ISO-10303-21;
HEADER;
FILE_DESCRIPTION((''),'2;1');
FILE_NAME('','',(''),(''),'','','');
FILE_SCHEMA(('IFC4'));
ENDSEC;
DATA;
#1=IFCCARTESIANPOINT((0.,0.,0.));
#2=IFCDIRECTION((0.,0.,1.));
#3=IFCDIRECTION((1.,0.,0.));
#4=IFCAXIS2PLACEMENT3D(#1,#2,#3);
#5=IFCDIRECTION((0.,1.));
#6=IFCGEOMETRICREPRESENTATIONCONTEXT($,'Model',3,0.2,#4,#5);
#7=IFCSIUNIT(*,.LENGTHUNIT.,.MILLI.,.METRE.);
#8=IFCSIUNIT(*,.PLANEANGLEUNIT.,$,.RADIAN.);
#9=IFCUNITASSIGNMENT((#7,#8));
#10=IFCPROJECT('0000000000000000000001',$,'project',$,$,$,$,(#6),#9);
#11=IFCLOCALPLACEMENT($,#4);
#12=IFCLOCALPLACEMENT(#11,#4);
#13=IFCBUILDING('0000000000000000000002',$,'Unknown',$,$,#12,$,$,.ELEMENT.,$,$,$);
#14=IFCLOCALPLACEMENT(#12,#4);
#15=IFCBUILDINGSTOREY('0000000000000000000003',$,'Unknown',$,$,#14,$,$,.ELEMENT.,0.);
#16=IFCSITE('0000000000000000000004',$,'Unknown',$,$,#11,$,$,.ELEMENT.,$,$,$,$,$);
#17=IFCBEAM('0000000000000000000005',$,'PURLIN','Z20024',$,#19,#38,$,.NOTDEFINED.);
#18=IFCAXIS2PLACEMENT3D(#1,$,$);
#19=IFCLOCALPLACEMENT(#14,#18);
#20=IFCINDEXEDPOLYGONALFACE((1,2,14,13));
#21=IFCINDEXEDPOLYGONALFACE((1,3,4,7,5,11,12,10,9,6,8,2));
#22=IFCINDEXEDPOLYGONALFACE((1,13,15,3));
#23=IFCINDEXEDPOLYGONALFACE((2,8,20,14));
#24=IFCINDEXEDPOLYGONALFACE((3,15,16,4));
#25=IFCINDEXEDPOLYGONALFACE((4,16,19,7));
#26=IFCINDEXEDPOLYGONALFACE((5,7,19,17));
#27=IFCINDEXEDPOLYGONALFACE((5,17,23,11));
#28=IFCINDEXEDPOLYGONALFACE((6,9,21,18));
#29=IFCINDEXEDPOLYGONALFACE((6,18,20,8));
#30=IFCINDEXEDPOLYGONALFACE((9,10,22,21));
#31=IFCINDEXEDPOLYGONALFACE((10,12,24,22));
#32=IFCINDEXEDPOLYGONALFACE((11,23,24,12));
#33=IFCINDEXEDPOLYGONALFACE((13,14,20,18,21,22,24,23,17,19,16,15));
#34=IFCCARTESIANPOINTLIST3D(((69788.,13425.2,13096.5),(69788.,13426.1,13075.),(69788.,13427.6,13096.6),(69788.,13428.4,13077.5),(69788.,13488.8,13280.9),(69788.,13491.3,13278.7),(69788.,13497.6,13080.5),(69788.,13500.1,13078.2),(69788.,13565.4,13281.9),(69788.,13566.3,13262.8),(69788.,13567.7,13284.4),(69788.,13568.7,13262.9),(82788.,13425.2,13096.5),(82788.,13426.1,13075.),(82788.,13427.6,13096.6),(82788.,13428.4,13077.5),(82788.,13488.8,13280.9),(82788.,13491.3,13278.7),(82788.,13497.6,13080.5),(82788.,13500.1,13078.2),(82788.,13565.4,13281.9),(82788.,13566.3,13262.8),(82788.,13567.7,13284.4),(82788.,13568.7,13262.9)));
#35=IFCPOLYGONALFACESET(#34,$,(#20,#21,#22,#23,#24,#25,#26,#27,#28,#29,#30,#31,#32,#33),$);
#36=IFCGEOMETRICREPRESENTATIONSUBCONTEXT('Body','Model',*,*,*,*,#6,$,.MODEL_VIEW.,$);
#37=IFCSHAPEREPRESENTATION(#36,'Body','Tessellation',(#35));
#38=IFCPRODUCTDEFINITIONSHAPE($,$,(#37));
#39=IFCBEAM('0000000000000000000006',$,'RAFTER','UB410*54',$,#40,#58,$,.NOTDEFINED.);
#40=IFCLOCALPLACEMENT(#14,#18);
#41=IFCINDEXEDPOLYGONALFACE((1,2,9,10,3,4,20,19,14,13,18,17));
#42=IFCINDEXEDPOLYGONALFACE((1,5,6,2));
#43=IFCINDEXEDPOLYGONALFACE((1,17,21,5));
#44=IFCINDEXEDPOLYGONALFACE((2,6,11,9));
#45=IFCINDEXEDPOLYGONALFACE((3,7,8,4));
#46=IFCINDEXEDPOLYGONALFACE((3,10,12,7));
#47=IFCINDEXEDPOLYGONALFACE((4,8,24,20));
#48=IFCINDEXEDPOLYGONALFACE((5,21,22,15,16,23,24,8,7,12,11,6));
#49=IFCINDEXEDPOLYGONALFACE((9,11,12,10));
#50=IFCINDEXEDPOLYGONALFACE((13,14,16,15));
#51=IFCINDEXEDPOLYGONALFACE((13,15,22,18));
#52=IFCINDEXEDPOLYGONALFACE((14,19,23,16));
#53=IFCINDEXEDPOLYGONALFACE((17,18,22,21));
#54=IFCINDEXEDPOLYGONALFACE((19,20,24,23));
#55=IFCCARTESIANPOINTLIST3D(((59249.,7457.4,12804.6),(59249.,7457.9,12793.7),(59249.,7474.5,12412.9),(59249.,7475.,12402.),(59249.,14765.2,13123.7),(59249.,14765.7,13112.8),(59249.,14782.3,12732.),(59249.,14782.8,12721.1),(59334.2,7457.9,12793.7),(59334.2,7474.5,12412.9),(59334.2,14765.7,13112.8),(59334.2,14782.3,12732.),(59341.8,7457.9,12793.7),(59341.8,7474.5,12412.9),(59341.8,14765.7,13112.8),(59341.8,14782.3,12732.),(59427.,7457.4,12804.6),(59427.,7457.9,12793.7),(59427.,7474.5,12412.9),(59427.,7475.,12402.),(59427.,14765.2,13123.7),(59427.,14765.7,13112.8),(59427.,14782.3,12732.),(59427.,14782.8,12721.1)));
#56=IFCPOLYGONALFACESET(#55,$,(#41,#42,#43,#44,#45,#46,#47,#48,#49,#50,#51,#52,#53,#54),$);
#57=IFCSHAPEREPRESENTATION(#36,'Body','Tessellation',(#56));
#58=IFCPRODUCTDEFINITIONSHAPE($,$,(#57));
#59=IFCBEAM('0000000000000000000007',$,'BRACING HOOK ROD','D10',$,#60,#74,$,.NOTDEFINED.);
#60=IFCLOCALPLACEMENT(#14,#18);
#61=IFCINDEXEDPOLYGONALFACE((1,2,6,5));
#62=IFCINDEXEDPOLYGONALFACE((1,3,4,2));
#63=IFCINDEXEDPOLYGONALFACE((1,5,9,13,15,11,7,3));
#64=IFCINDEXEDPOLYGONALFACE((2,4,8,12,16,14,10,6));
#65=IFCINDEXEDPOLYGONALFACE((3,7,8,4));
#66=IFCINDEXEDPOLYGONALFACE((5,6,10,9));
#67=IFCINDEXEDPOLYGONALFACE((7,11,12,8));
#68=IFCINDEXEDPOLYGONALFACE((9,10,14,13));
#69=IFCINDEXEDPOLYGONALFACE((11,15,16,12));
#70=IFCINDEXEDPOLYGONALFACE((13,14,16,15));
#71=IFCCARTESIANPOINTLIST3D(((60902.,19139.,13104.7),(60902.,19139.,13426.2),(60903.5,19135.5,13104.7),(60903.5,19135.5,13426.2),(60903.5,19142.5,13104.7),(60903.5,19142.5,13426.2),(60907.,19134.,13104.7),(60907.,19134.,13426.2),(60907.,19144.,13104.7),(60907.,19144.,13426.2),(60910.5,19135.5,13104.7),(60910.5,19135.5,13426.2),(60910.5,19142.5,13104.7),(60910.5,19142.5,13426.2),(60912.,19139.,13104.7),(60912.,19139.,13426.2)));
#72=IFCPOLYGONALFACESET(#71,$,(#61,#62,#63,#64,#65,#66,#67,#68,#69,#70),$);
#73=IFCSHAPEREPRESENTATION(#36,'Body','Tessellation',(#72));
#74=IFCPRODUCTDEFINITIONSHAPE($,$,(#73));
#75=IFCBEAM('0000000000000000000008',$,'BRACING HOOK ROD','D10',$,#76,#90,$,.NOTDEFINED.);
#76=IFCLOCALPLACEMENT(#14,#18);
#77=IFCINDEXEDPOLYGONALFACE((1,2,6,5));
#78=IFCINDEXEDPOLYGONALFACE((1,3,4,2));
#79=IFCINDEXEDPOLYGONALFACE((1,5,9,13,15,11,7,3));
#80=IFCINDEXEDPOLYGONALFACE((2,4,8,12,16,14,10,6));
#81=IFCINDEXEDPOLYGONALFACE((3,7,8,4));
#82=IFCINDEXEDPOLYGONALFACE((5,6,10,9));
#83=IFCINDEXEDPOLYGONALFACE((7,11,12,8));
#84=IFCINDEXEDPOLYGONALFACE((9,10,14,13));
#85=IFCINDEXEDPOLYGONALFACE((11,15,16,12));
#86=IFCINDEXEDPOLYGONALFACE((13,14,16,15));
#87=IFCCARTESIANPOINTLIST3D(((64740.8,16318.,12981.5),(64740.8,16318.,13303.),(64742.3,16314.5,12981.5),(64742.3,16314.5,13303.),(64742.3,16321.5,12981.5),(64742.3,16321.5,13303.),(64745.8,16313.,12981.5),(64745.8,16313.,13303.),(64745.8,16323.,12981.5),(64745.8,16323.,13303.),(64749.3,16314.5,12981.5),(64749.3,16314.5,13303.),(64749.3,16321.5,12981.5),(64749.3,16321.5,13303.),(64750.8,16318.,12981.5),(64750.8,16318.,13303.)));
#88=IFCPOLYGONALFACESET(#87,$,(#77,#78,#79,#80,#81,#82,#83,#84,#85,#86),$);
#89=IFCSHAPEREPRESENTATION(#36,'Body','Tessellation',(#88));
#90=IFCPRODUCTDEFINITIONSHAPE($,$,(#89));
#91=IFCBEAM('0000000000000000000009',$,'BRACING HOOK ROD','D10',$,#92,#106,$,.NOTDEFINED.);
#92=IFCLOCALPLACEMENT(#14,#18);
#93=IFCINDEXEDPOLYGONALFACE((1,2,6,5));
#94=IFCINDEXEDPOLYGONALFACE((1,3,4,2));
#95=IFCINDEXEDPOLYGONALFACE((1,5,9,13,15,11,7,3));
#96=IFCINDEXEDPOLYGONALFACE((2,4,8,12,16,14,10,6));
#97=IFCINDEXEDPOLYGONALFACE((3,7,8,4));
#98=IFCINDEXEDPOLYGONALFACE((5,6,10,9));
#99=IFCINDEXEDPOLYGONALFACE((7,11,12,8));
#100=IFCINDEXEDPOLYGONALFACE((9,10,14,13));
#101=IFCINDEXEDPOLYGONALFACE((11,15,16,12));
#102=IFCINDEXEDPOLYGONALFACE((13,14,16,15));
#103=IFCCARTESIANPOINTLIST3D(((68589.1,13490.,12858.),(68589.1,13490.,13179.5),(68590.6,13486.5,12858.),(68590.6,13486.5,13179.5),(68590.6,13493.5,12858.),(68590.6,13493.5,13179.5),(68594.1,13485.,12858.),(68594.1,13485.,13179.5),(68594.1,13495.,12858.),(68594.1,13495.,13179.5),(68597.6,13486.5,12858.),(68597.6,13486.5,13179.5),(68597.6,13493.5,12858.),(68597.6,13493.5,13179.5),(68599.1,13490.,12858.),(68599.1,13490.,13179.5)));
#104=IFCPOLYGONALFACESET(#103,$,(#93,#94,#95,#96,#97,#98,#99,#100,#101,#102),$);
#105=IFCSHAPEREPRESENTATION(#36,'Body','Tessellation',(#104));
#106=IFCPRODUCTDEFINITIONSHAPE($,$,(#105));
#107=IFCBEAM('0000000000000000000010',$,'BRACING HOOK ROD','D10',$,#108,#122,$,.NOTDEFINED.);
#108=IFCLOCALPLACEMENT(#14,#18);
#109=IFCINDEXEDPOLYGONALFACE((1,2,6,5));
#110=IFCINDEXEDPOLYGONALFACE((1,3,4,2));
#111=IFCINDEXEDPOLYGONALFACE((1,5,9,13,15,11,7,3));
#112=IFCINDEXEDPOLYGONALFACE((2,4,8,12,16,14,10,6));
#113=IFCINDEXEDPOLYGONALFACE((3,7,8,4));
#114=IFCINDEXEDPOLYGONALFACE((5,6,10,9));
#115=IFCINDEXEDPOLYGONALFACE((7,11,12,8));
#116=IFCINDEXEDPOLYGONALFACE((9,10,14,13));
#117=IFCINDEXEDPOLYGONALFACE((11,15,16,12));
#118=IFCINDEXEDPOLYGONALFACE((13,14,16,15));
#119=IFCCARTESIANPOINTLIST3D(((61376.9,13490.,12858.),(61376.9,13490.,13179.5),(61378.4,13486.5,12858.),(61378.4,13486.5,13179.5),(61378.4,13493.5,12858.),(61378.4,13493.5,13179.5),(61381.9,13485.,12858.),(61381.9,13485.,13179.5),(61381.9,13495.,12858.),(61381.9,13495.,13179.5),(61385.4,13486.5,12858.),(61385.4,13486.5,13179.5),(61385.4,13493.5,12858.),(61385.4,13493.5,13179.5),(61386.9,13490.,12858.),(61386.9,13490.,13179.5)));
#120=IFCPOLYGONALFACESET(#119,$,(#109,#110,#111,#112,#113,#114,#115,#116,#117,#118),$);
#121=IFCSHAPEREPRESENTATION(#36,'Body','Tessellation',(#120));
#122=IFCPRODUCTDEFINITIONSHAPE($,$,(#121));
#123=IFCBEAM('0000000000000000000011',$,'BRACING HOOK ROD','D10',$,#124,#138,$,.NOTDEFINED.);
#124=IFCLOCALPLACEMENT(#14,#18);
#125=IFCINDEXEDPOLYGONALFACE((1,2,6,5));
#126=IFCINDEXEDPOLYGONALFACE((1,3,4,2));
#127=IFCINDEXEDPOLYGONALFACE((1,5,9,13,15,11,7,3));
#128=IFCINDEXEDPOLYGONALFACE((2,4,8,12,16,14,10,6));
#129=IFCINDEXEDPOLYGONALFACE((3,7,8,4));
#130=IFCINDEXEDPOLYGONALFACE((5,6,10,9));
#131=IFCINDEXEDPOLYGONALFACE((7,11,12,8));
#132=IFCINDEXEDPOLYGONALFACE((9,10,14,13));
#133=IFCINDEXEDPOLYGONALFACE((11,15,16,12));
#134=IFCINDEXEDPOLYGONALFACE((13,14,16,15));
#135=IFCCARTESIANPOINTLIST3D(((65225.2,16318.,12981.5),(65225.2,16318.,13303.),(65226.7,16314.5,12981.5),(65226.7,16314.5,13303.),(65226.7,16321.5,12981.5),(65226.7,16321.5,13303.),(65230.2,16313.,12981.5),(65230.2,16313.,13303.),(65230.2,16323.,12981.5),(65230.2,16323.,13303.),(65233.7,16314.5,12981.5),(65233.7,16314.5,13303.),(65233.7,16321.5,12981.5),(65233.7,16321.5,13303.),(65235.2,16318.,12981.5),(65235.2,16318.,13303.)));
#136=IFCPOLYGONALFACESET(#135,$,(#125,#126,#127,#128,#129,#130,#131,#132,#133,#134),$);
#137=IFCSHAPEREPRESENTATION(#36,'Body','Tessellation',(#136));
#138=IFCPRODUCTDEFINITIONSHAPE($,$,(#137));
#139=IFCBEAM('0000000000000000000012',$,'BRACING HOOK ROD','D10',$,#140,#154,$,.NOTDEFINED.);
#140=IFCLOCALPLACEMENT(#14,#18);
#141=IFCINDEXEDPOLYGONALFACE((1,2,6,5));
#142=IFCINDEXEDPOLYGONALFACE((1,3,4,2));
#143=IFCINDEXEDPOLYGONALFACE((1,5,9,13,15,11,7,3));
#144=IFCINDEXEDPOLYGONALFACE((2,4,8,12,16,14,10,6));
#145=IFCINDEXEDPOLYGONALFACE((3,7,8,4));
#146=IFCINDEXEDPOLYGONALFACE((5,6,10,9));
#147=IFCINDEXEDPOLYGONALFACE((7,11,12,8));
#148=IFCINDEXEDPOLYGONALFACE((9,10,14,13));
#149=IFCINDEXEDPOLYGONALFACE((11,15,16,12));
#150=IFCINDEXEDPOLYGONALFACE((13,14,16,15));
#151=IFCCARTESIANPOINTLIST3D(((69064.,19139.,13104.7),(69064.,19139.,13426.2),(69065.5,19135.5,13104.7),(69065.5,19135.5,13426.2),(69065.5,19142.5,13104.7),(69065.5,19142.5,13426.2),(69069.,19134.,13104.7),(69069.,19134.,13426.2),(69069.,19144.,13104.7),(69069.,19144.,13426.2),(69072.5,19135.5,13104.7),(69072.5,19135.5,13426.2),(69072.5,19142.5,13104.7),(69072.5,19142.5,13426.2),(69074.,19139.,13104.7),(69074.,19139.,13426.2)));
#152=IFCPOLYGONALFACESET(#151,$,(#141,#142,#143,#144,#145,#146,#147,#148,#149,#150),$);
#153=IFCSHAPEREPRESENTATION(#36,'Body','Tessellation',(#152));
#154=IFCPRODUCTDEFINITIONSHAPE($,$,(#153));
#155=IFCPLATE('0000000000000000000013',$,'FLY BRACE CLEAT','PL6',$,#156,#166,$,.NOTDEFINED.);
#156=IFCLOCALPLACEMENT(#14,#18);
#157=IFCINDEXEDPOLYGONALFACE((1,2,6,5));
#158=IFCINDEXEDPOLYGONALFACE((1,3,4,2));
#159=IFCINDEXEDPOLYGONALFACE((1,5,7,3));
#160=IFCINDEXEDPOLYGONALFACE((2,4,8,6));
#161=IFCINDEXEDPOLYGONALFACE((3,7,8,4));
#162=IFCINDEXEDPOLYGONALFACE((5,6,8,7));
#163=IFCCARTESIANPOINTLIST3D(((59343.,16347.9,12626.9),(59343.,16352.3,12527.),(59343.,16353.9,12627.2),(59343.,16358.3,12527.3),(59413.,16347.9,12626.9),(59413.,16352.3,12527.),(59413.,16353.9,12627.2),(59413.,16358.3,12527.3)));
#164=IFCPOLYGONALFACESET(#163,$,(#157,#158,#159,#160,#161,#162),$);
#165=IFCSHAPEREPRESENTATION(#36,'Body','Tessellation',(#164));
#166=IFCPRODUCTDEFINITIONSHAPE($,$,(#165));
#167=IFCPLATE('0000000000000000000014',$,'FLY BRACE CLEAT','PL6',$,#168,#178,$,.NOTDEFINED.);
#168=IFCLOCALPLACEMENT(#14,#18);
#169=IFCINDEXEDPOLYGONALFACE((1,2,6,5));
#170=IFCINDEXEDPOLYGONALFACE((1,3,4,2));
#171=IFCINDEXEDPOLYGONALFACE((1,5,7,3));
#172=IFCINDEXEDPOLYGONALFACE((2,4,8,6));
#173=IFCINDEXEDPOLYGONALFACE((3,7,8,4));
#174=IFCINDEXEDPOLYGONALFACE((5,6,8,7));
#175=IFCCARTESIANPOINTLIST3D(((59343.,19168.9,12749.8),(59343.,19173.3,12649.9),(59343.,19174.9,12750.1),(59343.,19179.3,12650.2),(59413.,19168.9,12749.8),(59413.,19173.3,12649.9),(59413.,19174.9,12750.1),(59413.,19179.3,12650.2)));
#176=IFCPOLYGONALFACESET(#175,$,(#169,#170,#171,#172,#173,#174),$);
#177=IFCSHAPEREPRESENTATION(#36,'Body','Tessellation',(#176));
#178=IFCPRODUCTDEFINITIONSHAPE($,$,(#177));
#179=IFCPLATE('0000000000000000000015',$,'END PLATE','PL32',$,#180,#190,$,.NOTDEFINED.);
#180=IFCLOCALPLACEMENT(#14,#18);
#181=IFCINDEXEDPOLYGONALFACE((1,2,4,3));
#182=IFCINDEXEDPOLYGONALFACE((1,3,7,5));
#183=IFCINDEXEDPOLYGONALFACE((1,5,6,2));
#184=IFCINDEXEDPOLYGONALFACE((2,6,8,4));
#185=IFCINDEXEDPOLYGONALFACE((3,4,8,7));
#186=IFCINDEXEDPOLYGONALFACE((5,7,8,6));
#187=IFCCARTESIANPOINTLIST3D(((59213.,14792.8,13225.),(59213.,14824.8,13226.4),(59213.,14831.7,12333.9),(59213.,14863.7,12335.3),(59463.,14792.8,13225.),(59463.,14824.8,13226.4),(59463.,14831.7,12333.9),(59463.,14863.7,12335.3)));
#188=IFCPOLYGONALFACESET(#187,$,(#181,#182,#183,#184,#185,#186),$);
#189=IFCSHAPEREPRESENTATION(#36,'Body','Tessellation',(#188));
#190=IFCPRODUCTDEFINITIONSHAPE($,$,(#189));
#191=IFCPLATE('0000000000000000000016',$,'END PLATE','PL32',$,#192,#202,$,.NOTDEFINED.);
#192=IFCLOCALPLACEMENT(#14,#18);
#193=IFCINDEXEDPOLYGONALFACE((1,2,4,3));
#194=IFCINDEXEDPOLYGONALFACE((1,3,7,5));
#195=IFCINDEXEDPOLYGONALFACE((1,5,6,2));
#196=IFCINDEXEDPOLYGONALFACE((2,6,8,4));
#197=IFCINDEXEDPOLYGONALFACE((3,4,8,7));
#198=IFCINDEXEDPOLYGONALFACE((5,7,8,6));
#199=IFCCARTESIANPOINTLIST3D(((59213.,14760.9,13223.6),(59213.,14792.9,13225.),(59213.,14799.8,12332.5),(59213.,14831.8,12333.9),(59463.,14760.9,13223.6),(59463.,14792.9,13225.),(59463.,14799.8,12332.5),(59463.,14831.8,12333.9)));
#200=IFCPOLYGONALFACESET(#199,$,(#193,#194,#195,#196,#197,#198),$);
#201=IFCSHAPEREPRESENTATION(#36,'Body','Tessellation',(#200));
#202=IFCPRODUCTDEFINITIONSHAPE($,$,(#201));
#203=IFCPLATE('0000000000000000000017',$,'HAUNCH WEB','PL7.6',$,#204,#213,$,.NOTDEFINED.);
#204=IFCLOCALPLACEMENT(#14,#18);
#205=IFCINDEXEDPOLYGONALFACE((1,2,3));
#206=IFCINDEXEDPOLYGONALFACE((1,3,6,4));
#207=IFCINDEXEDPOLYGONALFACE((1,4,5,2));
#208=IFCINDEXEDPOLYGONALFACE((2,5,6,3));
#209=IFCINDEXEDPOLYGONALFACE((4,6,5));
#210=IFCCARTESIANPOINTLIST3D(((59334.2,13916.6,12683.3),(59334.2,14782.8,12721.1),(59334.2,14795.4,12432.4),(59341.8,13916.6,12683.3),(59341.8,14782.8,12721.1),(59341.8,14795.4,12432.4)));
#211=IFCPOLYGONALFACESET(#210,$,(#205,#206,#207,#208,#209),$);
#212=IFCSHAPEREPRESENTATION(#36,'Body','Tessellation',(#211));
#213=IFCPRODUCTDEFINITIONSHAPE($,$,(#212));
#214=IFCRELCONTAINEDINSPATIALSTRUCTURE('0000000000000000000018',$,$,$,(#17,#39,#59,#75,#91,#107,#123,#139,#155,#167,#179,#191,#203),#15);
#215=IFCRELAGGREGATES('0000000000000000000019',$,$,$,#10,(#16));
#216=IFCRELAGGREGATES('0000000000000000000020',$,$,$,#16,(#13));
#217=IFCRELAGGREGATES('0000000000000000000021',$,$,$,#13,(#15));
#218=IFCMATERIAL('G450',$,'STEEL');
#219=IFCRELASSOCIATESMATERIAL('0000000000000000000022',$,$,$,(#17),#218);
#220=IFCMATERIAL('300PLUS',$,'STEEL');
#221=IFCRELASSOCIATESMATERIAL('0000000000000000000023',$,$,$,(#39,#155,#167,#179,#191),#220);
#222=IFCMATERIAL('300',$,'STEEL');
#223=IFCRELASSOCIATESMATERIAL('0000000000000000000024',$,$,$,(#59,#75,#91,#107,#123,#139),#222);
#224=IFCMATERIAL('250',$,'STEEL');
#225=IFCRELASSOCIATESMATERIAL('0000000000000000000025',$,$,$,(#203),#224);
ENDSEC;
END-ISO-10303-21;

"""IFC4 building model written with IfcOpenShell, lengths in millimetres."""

from ifc_helpers import new_model, si_unit, direction, frame, origin_with_axes, place, context, subcontext, project, spatial, line, indexed_curve, outline, extrude, material, element, save


model = new_model("IFC4")

# Units and contexts
model_context = context("Model", 3, precision=0.2, world=origin_with_axes(), true_north=direction((0.0, 1.0)))
body_context = subcontext(model_context, "Body", "Model", "MODEL_VIEW")
ifc_project = project(units=[si_unit("LENGTHUNIT", "METRE", prefix="MILLI"), si_unit("PLANEANGLEUNIT", "RADIAN")], contexts=[model_context])

# Site, building, storey
site_placement = place(None, origin_with_axes())
site = spatial("IfcSite", under=ifc_project, at=site_placement, Name="Unknown", CompositionType="ELEMENT")
building_placement = place(site_placement, origin_with_axes())
building = spatial("IfcBuilding", under=site, at=building_placement, Name="Unknown", CompositionType="ELEMENT")
storey_placement = place(building_placement, origin_with_axes())
storey = spatial("IfcBuildingStorey", under=building, at=storey_placement, Name="Unknown", CompositionType="ELEMENT", Elevation=0.0)

# Shared definitions
ifc_material_1 = material(Name="300PLUS", Category="STEEL")

# Beams
ifc_material_2 = material(Name="G450", Category="STEEL")
for number, where, z_axis, x_axis, name in (
    (1, (69788.0, 13494.4, 13179.6), (0.0, -0.999048, -0.043619), (1.0, 0.0, 0.0), "PURLIN"),
):
    element("IfcBeam", number, at=place(storey_placement, frame(where, z_axis=z_axis, x_axis=x_axis)), inside=storey, material=ifc_material_2, Name=name, Description="Z20024", PredefinedType="NOTDEFINED", context=body_context, shape_type="SolidModel", body=[
        extrude(outline(indexed_curve([(72.8, -101.5), (72.8, -80.0), (70.4, -80.0), (70.4, -99.1), (1.2, -99.1), (1.2, 101.5), (-77.8, 101.5), (-77.8, 80.0), (-75.4, 80.0), (-75.4, 99.1), (-1.2, 99.1), (-1.2, -101.5)], segments=[line(1, 2, 3, 4, 5, 6, 7, 8, 9, 10, 11, 12, 1)])), frame((0.0, 0.0, 0.0), z_axis=(-1.0, 0.0, 0.0), x_axis=(0.0, 0.0, 1.0)), (0.0, 0.0, -1.0), 13000.0),
    ])
beam_placement = place(storey_placement, frame((59338.0, 14774.0, 12922.4), z_axis=(-1.0, 0.0, 0.0), x_axis=(0.0, -0.999048, -0.043624)))
element("IfcBeam", 2, at=beam_placement, inside=storey, material=ifc_material_1, Name="RAFTER", Description="UB410*54", PredefinedType="NOTDEFINED", context=body_context, shape_type="SolidModel", body=[
    extrude(outline(indexed_curve([(-89.0, -201.5), (89.0, -201.5), (89.0, -190.6), (3.8, -190.6), (3.8, 190.6), (89.0, 190.6), (89.0, 201.5), (-89.0, 201.5), (-89.0, 190.6), (-3.8, 190.6), (-3.8, -190.6), (-89.0, -190.6)], segments=[line(1, 2, 3, 4, 5, 6, 7, 8, 9, 10, 11, 12, 1)])), frame((0.0, 0.0, 0.0), z_axis=(-1.0, 0.0, 0.0), x_axis=(0.0, 0.0, 1.0)), (0.0, 0.0, -1.0), 7314.8),
])
ifc_material_3 = material(Name="300", Category="STEEL")
for number, where, z_axis, x_axis, name in (
    (3, (60907.0, 19139.0, 13426.2), (1.0, 0.0, 0.0), (0.0, 0.0, -1.0), "BRACING HOOK ROD"),
    (4, (64745.8, 16318.0, 13303.0), (1.0, 0.0, 0.0), (0.0, 0.0, -1.0), "BRACING HOOK ROD"),
    (5, (68594.1, 13490.0, 13179.5), (1.0, 0.0, 0.0), (0.0, 0.0, -1.0), "BRACING HOOK ROD"),
    (6, (61381.9, 13490.0, 13179.5), (1.0, 0.0, 0.0), (0.0, 0.0, -1.0), "BRACING HOOK ROD"),
    (7, (65230.2, 16318.0, 13303.0), (1.0, 0.0, 0.0), (0.0, 0.0, -1.0), "BRACING HOOK ROD"),
    (8, (69069.0, 19139.0, 13426.2), (1.0, 0.0, 0.0), (0.0, 0.0, -1.0), "BRACING HOOK ROD"),
):
    element("IfcBeam", number, at=place(storey_placement, frame(where, z_axis=z_axis, x_axis=x_axis)), inside=storey, material=ifc_material_3, Name=name, Description="D10", PredefinedType="NOTDEFINED", context=body_context, shape_type="SolidModel", body=[
        extrude(outline(indexed_curve([(5.0, 0.0), (3.5, 3.5), (0.0, 5.0), (-3.5, 3.5), (-5.0, 0.0), (-3.5, -3.5), (0.0, -5.0), (3.5, -3.5)], segments=[line(1, 2, 3, 4, 5, 6, 7, 8, 1)])), frame((0.0, 0.0, 0.0), z_axis=(-1.0, 0.0, 0.0), x_axis=(0.0, 0.0, 1.0)), (0.0, 0.0, -1.0), 321.5),
    ])

# Plates
for number, where, z_axis, x_axis, name in (
    (9, (59343.0, 16350.9, 12627.0), (0.0, 0.999031, 0.044001), (1.0, 0.0, 0.0), "FLY BRACE CLEAT"),
    (10, (59343.0, 19171.9, 12749.9), (0.0, 0.999031, 0.044001), (1.0, 0.0, 0.0), "FLY BRACE CLEAT"),
):
    element("IfcPlate", number, at=place(storey_placement, frame(where, z_axis=z_axis, x_axis=x_axis)), inside=storey, material=ifc_material_1, Name=name, Description="PL6", PredefinedType="NOTDEFINED", context=body_context, shape_type="SolidModel", body=[
        extrude(outline(indexed_curve([(0.0, 0.0), (70.0, 0.0), (70.0, 100.0), (0.0, 100.0)], segments=[line(1, 2, 3, 4, 1)])), frame((0.0, 0.0, 3.0), z_axis=(0.0, 0.0, 1.0), x_axis=(1.0, 0.0, 0.0)), (0.0, 0.0, -1.0), 6.0),
    ])
for number, where, z_axis, x_axis, name in (
    (11, (59463.0, 14847.7, 12334.6), (0.0, 0.999049, 0.043612), (-1.0, 0.0, 0.0), "END PLATE"),
    (12, (59463.0, 14815.8, 12333.2), (0.0, 0.999049, 0.043612), (-1.0, 0.0, 0.0), "END PLATE"),
):
    element("IfcPlate", number, at=place(storey_placement, frame(where, z_axis=z_axis, x_axis=x_axis)), inside=storey, material=ifc_material_1, Name=name, Description="PL32", PredefinedType="NOTDEFINED", context=body_context, shape_type="SolidModel", body=[
        extrude(outline(indexed_curve([(0.0, 0.0), (250.0, 0.0), (250.0, 891.9), (0.0, 891.9)], segments=[line(1, 2, 3, 4, 1)])), frame((0.0, 0.0, 16.0), z_axis=(0.0, 0.0, 1.0), x_axis=(1.0, 0.0, 0.0)), (0.0, 0.0, -1.0), 32.0),
    ])
ifc_material_4 = material(Name="250", Category="STEEL")
plate_1_placement = place(storey_placement, frame((59338.0, 14782.8, 12721.1), z_axis=(-1.0, 0.0, 0.0), x_axis=(0.0, 0.043602, -0.999049)))
element("IfcPlate", 13, at=plate_1_placement, inside=storey, material=ifc_material_4, Name="HAUNCH WEB", Description="PL7.6", PredefinedType="NOTDEFINED", context=body_context, shape_type="SolidModel", body=[
    extrude(outline(indexed_curve([(0.0, 0.0), (289.0, 0.0), (0.0, 867.0)], segments=[line(1, 2, 3, 1)])), frame((0.0, 0.0, 3.8), z_axis=(0.0, 0.0, 1.0), x_axis=(1.0, 0.0, 0.0)), (0.0, 0.0, -1.0), 7.6),
])

save(model, "model.ifc")
